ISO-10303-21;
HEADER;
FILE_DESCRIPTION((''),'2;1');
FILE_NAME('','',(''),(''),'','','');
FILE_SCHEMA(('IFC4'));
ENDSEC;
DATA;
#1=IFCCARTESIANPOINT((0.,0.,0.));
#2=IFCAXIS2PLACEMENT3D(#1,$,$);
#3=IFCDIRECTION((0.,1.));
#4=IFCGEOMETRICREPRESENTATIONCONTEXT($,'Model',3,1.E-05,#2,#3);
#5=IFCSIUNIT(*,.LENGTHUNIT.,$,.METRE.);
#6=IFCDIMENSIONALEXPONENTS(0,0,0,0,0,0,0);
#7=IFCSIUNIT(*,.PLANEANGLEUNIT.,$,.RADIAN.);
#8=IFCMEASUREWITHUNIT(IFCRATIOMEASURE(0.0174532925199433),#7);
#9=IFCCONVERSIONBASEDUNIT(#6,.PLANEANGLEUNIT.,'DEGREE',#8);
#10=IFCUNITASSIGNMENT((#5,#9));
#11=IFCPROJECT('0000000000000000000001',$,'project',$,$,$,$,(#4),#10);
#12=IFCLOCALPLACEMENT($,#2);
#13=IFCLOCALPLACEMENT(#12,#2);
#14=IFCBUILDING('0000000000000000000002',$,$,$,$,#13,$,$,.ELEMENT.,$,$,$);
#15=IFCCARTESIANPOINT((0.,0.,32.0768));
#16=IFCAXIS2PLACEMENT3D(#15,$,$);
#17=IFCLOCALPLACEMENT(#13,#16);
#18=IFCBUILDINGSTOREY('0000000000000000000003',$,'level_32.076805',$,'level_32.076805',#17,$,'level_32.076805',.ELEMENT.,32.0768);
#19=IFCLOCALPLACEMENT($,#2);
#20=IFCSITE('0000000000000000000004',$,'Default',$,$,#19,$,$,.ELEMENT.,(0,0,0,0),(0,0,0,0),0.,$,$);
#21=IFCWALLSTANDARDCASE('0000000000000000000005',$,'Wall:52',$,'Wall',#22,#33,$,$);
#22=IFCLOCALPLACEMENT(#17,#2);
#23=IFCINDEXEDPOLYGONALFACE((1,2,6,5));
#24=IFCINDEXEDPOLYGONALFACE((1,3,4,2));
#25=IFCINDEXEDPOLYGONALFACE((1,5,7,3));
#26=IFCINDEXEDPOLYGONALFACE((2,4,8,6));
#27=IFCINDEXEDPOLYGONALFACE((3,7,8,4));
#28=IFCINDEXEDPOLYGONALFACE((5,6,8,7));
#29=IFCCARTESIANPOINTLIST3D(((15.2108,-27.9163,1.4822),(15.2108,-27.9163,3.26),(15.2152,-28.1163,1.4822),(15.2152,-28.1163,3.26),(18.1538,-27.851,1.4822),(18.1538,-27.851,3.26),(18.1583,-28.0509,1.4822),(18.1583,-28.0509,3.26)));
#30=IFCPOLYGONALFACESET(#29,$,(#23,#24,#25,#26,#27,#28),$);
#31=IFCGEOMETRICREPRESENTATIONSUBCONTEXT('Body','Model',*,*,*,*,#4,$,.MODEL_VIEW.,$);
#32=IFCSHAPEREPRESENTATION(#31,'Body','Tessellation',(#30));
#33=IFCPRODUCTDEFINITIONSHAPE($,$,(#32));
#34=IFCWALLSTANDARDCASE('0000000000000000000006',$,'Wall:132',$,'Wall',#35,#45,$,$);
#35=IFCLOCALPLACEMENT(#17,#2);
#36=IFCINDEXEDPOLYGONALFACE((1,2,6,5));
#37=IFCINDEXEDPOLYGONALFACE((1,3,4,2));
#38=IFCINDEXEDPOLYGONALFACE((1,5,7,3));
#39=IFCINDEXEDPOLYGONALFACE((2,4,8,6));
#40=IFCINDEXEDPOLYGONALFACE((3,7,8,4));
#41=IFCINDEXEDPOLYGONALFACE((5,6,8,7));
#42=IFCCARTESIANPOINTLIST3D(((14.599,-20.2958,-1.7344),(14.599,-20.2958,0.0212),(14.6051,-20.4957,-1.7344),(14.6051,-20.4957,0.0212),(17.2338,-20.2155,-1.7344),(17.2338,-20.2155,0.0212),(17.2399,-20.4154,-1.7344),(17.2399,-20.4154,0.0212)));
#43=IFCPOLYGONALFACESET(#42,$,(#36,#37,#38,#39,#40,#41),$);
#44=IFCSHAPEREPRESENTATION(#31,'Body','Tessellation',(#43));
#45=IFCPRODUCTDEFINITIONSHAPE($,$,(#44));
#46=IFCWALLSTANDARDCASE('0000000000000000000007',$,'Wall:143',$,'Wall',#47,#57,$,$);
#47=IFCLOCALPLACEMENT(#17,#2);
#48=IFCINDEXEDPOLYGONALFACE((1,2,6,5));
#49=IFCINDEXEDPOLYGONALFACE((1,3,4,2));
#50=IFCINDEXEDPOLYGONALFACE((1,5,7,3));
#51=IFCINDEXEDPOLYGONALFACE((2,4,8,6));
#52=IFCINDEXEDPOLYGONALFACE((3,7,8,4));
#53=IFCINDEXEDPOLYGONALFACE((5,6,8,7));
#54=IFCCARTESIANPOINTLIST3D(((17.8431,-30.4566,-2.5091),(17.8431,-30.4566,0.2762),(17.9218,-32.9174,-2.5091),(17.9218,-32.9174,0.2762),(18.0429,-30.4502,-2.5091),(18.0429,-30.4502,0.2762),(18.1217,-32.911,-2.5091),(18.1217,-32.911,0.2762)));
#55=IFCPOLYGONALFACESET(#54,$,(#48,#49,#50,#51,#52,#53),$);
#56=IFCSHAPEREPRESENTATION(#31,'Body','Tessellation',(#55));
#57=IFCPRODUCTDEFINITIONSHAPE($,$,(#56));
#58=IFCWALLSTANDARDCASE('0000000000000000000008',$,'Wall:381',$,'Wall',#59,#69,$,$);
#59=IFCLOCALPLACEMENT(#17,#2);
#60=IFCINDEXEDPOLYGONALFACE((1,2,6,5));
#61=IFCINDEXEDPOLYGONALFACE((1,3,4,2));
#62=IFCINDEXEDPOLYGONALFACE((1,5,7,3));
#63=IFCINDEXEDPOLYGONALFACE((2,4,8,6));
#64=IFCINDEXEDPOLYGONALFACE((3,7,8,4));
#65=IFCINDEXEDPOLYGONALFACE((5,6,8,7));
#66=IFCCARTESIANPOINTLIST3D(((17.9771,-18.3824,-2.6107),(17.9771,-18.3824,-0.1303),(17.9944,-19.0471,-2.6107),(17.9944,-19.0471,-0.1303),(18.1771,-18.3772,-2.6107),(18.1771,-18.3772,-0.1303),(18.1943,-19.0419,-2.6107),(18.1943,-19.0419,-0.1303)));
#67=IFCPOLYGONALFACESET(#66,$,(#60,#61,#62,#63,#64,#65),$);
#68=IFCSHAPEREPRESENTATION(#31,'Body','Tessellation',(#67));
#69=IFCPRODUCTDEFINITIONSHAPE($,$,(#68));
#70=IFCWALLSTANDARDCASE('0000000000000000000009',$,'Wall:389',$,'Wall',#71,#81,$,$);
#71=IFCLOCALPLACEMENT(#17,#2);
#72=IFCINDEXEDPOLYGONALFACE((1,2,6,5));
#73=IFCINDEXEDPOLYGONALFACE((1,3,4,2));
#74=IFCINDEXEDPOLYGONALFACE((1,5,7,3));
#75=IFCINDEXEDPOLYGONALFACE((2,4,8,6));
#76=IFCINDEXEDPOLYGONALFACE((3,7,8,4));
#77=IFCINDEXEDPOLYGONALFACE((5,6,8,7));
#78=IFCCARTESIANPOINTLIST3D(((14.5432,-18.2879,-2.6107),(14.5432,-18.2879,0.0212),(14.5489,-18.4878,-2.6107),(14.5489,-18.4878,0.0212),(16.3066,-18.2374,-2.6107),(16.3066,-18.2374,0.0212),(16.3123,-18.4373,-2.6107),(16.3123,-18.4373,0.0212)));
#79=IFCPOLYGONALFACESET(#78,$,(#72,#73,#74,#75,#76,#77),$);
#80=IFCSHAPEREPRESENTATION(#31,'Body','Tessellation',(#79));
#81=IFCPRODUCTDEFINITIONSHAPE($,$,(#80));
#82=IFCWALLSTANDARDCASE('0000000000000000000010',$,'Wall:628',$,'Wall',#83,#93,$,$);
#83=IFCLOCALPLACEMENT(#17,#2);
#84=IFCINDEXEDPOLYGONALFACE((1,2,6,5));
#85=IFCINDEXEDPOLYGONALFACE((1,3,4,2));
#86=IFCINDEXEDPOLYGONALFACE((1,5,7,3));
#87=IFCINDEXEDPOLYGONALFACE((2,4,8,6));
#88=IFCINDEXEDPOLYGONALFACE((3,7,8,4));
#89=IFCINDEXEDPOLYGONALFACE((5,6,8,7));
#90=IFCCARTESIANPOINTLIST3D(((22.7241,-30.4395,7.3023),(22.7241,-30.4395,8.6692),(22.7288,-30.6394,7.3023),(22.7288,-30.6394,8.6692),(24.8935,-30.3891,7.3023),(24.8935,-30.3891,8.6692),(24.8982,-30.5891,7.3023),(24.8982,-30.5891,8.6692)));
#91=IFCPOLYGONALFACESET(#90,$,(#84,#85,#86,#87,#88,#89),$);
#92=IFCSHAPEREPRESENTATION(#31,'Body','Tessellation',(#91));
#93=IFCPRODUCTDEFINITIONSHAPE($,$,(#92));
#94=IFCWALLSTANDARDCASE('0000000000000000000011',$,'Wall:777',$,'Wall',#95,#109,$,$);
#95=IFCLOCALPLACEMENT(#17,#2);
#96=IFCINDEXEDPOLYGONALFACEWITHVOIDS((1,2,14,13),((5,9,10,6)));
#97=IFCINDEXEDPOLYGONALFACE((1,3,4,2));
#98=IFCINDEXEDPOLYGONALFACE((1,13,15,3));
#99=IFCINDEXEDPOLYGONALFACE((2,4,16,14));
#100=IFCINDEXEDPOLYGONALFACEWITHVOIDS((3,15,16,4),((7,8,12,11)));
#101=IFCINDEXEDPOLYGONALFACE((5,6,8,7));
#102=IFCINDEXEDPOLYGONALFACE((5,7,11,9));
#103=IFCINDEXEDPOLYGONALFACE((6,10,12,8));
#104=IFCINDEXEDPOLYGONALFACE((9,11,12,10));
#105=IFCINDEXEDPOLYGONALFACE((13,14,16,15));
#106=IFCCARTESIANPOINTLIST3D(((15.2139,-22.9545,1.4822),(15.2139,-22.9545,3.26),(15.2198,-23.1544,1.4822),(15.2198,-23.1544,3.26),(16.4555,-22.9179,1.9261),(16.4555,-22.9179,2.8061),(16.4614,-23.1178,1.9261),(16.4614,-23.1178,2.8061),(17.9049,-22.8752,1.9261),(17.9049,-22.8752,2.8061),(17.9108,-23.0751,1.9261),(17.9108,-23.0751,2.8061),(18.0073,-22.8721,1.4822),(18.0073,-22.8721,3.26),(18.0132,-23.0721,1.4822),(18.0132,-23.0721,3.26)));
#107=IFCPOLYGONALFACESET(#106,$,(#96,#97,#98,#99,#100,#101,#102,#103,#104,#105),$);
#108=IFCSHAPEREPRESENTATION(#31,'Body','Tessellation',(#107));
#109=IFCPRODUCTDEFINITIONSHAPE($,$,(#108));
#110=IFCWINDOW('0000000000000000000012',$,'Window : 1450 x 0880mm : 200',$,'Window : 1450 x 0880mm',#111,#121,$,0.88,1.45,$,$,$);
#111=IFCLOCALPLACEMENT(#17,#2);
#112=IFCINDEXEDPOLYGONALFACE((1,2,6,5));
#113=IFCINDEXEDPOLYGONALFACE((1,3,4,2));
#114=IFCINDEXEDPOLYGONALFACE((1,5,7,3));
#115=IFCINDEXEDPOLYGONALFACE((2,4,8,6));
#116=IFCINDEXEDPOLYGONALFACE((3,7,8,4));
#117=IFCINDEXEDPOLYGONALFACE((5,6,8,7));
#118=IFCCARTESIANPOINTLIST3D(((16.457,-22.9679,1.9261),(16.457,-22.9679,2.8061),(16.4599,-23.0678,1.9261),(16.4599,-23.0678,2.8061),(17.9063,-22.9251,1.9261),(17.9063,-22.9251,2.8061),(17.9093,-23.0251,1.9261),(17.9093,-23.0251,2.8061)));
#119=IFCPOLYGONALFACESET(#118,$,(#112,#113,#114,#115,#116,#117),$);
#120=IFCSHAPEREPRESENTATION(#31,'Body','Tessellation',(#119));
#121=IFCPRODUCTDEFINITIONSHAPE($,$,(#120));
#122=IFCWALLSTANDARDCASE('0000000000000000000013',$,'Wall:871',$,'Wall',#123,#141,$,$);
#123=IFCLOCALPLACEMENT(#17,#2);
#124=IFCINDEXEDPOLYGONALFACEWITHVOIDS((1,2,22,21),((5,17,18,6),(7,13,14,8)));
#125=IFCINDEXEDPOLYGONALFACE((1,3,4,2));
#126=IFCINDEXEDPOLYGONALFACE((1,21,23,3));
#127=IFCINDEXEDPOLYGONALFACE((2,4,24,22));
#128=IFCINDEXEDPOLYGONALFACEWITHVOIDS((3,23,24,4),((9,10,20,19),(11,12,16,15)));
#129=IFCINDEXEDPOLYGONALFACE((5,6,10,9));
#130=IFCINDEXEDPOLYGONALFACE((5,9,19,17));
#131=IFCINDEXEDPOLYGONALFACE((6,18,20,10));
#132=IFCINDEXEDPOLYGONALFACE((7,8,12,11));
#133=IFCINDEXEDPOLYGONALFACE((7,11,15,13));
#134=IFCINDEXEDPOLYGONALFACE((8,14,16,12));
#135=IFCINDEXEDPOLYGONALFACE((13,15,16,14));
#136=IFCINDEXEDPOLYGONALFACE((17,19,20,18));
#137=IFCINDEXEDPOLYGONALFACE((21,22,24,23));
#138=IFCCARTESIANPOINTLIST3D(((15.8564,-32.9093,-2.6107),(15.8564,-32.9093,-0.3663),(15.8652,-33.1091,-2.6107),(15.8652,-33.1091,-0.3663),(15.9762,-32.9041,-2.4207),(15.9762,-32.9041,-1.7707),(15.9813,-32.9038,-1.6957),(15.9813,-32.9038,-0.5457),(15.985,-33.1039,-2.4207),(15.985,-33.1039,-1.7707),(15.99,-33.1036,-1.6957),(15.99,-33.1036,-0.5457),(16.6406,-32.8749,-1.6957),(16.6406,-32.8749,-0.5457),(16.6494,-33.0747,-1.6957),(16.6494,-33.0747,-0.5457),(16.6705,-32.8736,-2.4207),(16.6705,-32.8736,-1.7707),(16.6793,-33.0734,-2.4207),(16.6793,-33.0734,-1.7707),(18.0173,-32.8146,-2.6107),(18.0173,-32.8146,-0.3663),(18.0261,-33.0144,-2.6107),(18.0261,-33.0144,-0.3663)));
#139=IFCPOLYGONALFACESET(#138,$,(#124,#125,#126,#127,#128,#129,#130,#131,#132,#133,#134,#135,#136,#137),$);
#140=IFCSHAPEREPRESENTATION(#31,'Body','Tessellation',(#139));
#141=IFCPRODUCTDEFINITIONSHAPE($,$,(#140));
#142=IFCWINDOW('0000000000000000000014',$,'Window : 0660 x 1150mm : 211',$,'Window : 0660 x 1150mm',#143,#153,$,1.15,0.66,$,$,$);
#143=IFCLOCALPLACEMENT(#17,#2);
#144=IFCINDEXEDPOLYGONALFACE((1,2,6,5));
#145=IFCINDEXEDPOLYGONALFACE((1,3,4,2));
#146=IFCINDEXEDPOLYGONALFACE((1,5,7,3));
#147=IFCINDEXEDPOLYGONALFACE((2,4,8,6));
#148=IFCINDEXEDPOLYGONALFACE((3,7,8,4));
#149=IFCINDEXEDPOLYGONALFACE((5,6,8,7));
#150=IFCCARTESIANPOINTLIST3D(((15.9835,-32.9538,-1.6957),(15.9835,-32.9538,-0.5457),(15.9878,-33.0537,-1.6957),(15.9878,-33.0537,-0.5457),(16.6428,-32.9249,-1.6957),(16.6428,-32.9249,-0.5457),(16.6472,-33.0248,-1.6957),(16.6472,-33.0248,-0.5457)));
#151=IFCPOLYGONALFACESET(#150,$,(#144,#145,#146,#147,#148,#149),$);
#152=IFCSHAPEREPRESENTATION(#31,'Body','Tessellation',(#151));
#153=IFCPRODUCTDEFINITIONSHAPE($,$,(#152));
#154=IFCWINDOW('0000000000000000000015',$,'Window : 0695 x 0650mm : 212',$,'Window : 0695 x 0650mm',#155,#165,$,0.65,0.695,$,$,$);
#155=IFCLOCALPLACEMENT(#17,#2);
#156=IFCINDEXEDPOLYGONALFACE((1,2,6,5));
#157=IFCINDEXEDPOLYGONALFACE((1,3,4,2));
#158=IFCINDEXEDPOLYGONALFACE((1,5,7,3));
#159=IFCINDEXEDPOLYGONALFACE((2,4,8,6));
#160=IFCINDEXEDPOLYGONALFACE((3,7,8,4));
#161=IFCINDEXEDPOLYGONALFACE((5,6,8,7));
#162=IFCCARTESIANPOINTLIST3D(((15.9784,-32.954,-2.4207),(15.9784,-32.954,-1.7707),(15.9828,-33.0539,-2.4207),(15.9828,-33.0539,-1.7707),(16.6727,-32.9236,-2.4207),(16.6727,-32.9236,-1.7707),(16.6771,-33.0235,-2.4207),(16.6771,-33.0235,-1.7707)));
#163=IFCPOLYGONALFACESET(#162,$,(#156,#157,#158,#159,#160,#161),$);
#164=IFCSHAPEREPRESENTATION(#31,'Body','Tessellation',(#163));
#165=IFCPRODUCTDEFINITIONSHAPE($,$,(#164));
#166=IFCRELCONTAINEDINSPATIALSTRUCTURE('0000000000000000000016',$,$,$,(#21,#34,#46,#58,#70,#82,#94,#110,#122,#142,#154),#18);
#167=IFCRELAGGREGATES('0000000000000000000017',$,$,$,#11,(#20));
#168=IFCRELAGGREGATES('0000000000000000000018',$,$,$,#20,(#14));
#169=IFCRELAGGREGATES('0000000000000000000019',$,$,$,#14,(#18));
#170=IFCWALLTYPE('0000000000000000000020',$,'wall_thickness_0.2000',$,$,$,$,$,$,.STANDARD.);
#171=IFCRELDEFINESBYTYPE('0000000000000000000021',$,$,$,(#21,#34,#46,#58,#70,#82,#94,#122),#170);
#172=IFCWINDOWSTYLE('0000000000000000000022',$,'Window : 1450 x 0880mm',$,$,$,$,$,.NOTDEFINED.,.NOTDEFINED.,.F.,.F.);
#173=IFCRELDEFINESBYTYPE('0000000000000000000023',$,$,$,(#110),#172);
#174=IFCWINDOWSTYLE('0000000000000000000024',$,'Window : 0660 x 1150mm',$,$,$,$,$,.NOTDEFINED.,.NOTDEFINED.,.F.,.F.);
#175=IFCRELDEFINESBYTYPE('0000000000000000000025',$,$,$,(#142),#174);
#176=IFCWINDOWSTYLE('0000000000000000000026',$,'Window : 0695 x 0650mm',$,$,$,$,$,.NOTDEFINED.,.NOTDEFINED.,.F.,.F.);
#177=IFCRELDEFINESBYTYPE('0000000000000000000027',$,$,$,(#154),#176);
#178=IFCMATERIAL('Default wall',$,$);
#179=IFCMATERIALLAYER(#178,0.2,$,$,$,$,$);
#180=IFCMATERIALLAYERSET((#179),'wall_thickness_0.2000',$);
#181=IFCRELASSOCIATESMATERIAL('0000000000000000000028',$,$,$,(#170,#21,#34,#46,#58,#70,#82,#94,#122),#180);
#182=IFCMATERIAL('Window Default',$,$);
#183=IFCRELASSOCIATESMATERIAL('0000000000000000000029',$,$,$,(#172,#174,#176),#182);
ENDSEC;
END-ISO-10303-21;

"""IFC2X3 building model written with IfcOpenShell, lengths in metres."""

from ifc_helpers import new_model, entity, si_unit, converted_unit, direction, frame, frame_2d, origin, origin_2d_with_axis, place, context, subcontext, project, spatial, polyline, rectangle, outline, extrude, source, transform, mapped, material, layer, layer_set, layer_usage, type_object, type_shapes, element, fill, save


model = new_model("IFC2X3")

# Units and contexts
model_context = context("Model", 3, precision=1e-05, world=origin(), true_north=direction((0.0, 1.0)))
body_context = subcontext(model_context, "Body", "Model", "MODEL_VIEW")
ifc_project = project(units=[si_unit("LENGTHUNIT", "METRE"), converted_unit("PLANEANGLEUNIT", "DEGREE", entity("IfcRatioMeasure", 0.0174532925199433), si_unit("PLANEANGLEUNIT", "RADIAN"), dimensions=[0, 0, 0, 0, 0, 0, 0])], contexts=[model_context])

# Site, building, storey
site_placement = place(None, origin())
site = spatial("IfcSite", under=ifc_project, at=site_placement, Name="Default", CompositionType="ELEMENT", RefLatitude=(0, 0, 0, 0), RefLongitude=(0, 0, 0, 0), RefElevation=0.0)
placement_1 = place(None, origin())
building_placement = place(placement_1, origin())
building = spatial("IfcBuilding", under=site, at=building_placement, CompositionType="ELEMENT")
storey_placement = place(building_placement, frame((0.0, 0.0, 32.0768)))
storey = spatial("IfcBuildingStorey", under=building, at=storey_placement, Name="level_32.076805", ObjectType="level_32.076805", LongName="level_32.076805", CompositionType="ELEMENT", Elevation=32.0768)

# Walls
ifc_material_1 = material(Name="Default wall")
ifc_layer = layer(ifc_material_1, 0.2)
ifc_layer_set = layer_set([ifc_layer], Name="wall_thickness_0.2000")
ifc_layer_usage = layer_usage(ifc_layer_set, "AXIS2", "POSITIVE", -0.1)
wall_type = type_object("IfcWallType", Name="wall_thickness_0.2000", PredefinedType="STANDARD", material=ifc_layer_set)
placement_2 = place(building_placement, frame((0.0, 0.0, 33.559)))
wall_1_placement = place(placement_2, frame((15.213, -28.0163, 0.0), z_axis=(0.0, 0.0, 1.0), x_axis=(0.999753, 0.022205, 0.0)))
element("IfcWallStandardCase", 1, at=wall_1_placement, inside=storey, type_object=wall_type, material=ifc_layer_usage, Name="Wall:52", ObjectType="Wall", context=body_context, shape_type="SweptSolid", body=[
    extrude(outline(polyline([(2.9438, -0.1), (2.9438, 0.1), (0.0, 0.1), (0.0, -0.1), (2.9438, -0.1)])), origin(), (0.0, 0.0, 1.0), 1.7778),
])
placement_3 = place(building_placement, frame((0.0, 0.0, 30.3424)))
wall_2_placement = place(placement_3, frame((14.6021, -20.3957, 0.0), z_axis=(0.0, 0.0, 1.0), x_axis=(0.999535, 0.030477, 0.0)))
element("IfcWallStandardCase", 2, at=wall_2_placement, inside=storey, type_object=wall_type, material=ifc_layer_usage, Name="Wall:132", ObjectType="Wall", context=body_context, shape_type="SweptSolid", body=[
    extrude(outline(polyline([(2.636, -0.1), (2.636, 0.1), (0.0, 0.1), (0.0, -0.1), (2.636, -0.1)])), origin(), (0.0, 0.0, 1.0), 1.7557),
])
placement_4 = place(building_placement, frame((0.0, 0.0, 29.5677)))
wall_3_placement = place(placement_4, frame((18.0217, -32.9142, 0.0), z_axis=(0.0, 0.0, 1.0), x_axis=(-0.031966, 0.999489, 0.0)))
element("IfcWallStandardCase", 3, at=wall_3_placement, inside=storey, type_object=wall_type, material=ifc_layer_usage, Name="Wall:143", ObjectType="Wall", context=body_context, shape_type="SweptSolid", body=[
    extrude(outline(polyline([(2.4621, -0.1), (2.4621, 0.1), (0.0, 0.1), (0.0, -0.1), (2.4621, -0.1)])), origin(), (0.0, 0.0, 1.0), 2.7852),
])
placement_5 = place(building_placement, frame((0.0, 0.0, 29.4661)))
wall_4_placement = place(placement_5, frame((18.0771, -18.3798, 0.0), z_axis=(0.0, 0.0, 1.0), x_axis=(0.025986, -0.999662, 0.0)))
element("IfcWallStandardCase", 4, at=wall_4_placement, inside=storey, type_object=wall_type, material=ifc_layer_usage, Name="Wall:381", ObjectType="Wall", context=body_context, shape_type="SweptSolid", body=[
    extrude(outline(polyline([(0.665, -0.1), (0.665, 0.1), (0.0, 0.1), (0.0, -0.1), (0.665, -0.1)])), origin(), (0.0, 0.0, 1.0), 2.4805),
])
placement_6 = place(building_placement, frame((0.0, 0.0, 29.4661)))
wall_5_placement = place(placement_6, frame((16.3094, -18.3374, 0.0), z_axis=(0.0, 0.0, 1.0), x_axis=(-0.99959, -0.02862, 0.0)))
element("IfcWallStandardCase", 5, at=wall_5_placement, inside=storey, type_object=wall_type, material=ifc_layer_usage, Name="Wall:389", ObjectType="Wall", context=body_context, shape_type="SweptSolid", body=[
    extrude(outline(polyline([(1.7641, -0.1), (1.7641, 0.1), (0.0, 0.1), (0.0, -0.1), (1.7641, -0.1)])), origin(), (0.0, 0.0, 1.0), 2.632),
])
placement_7 = place(building_placement, frame((0.0, 0.0, 39.3791)))
wall_6_placement = place(placement_7, frame((22.7264, -30.5395, 0.0), z_axis=(0.0, 0.0, 1.0), x_axis=(0.999731, 0.023204, 0.0)))
element("IfcWallStandardCase", 6, at=wall_6_placement, inside=storey, type_object=wall_type, material=ifc_layer_usage, Name="Wall:628", ObjectType="Wall", context=body_context, shape_type="SweptSolid", body=[
    extrude(outline(polyline([(2.17, -0.1), (2.17, 0.1), (0.0, 0.1), (0.0, -0.1), (2.17, -0.1)])), origin(), (0.0, 0.0, 1.0), 1.3669),
])

# Wall, opening, window
placement_8 = place(building_placement, frame((0.0, 0.0, 33.559)))
wall_7_placement = place(placement_8, frame((15.2168, -23.0545, 0.0), z_axis=(0.0, 0.0, 1.0), x_axis=(0.999565, 0.029478, 0.0)))
wall_7 = element("IfcWallStandardCase", 7, at=wall_7_placement, inside=storey, type_object=wall_type, material=ifc_layer_usage, Name="Wall:777", ObjectType="Wall", context=body_context, shape_type="SweptSolid", body=[
    extrude(outline(polyline([(2.7947, -0.1), (2.7947, 0.1), (0.0, 0.1), (0.0, -0.1), (2.7947, -0.1)])), origin(), (0.0, 0.0, 1.0), 1.7778),
])
opening_1_placement = place(wall_7_placement, frame((1.2421, -0.1, 0.444)))
opening_1 = element("IfcOpeningElement", 8, at=opening_1_placement, cuts=wall_7, ObjectType="Opening", context=body_context, shape_type="SweptSolid", body=[
    extrude(rectangle(XDim=1.45, YDim=0.88, at=frame_2d((0.44, 0.725), x_axis=(0.0, 1.0))), frame((0.0, 0.0, 0.0), z_axis=(0.0, 1.0, 0.0), x_axis=(0.0, 0.0, 1.0)), (0.0, 0.0, 1.0), 0.2),
])
ifc_material_2 = material(Name="Window Default")
window_style_1 = type_object("IfcWindowStyle", Name="Window : 1450 x 0880mm", ConstructionType="NOTDEFINED", OperationType="NOTDEFINED", ParameterTakesPrecedence=False, Sizeable=False, material=ifc_material_2)
shared_shape_1 = source(origin(), body_context, "Body", "SweptSolid", [
    extrude(rectangle(XDim=0.1, YDim=1.45, at=origin_2d_with_axis()), frame((0.725, 0.1, 0.0), z_axis=(0.0, 0.0, 1.0), x_axis=(0.0, 1.0, 0.0)), (0.0, 0.0, 1.0), 0.88),
])
type_shapes(window_style_1, [shared_shape_1])
window_1_placement = place(opening_1_placement, origin())
window_1 = element("IfcWindow", 9, at=window_1_placement, inside=storey, type_object=window_style_1, Name="Window : 1450 x 0880mm : 200", ObjectType="Window : 1450 x 0880mm", OverallHeight=0.88, OverallWidth=1.45, context=body_context, shape_type="MappedRepresentation", body=[
    mapped(shared_shape_1, transform((0.0, 0.0, 0.0), scale=1.0)),
])
fill(opening_1, window_1)

# Wall, openings, windows
placement_9 = place(building_placement, frame((0.0, 0.0, 29.4661)))
wall_8_placement = place(placement_9, frame((18.0217, -32.9145, 0.0), z_axis=(0.0, 0.0, 1.0), x_axis=(-0.999041, -0.043775, 0.0)))
wall_8 = element("IfcWallStandardCase", 10, at=wall_8_placement, inside=storey, type_object=wall_type, material=ifc_layer_usage, Name="Wall:871", ObjectType="Wall", context=body_context, shape_type="SweptSolid", body=[
    extrude(outline(polyline([(2.163, -0.1), (2.163, 0.1), (0.0, 0.1), (0.0, -0.1), (2.163, -0.1)])), origin(), (0.0, 0.0, 1.0), 2.2444),
])
opening_2_placement = place(wall_8_placement, frame((1.378, -0.1, 0.9151)))
opening_2 = element("IfcOpeningElement", 11, at=opening_2_placement, cuts=wall_8, ObjectType="Opening", context=body_context, shape_type="SweptSolid", body=[
    extrude(rectangle(XDim=0.66, YDim=1.15, at=frame_2d((0.575, 0.33), x_axis=(0.0, 1.0))), frame((0.0, 0.0, 0.0), z_axis=(0.0, 1.0, 0.0), x_axis=(0.0, 0.0, 1.0)), (0.0, 0.0, 1.0), 0.2),
])
opening_3_placement = place(wall_8_placement, frame((1.3481, -0.1, 0.1901)))
opening_3 = element("IfcOpeningElement", 12, at=opening_3_placement, cuts=wall_8, ObjectType="Opening", context=body_context, shape_type="SweptSolid", body=[
    extrude(rectangle(XDim=0.695, YDim=0.65, at=frame_2d((0.325, 0.3475), x_axis=(0.0, 1.0))), frame((0.0, 0.0, 0.0), z_axis=(0.0, 1.0, 0.0), x_axis=(0.0, 0.0, 1.0)), (0.0, 0.0, 1.0), 0.2),
])
window_style_2 = type_object("IfcWindowStyle", Name="Window : 0660 x 1150mm", ConstructionType="NOTDEFINED", OperationType="NOTDEFINED", ParameterTakesPrecedence=False, Sizeable=False, material=ifc_material_2)
shared_shape_2 = source(origin(), body_context, "Body", "SweptSolid", [
    extrude(rectangle(XDim=0.1, YDim=0.66, at=origin_2d_with_axis()), frame((0.33, 0.1, 0.0), z_axis=(0.0, 0.0, 1.0), x_axis=(0.0, 1.0, 0.0)), (0.0, 0.0, 1.0), 1.15),
])
type_shapes(window_style_2, [shared_shape_2])
window_2_placement = place(opening_2_placement, origin())
window_2 = element("IfcWindow", 13, at=window_2_placement, inside=storey, type_object=window_style_2, Name="Window : 0660 x 1150mm : 211", ObjectType="Window : 0660 x 1150mm", OverallHeight=1.15, OverallWidth=0.66, context=body_context, shape_type="MappedRepresentation", body=[
    mapped(shared_shape_2, transform((0.0, 0.0, 0.0), scale=1.0)),
])
fill(opening_2, window_2)
window_style_3 = type_object("IfcWindowStyle", Name="Window : 0695 x 0650mm", ConstructionType="NOTDEFINED", OperationType="NOTDEFINED", ParameterTakesPrecedence=False, Sizeable=False, material=ifc_material_2)
shared_shape_3 = source(origin(), body_context, "Body", "SweptSolid", [
    extrude(rectangle(XDim=0.1, YDim=0.695, at=origin_2d_with_axis()), frame((0.3475, 0.1, 0.0), z_axis=(0.0, 0.0, 1.0), x_axis=(0.0, 1.0, 0.0)), (0.0, 0.0, 1.0), 0.65),
])
type_shapes(window_style_3, [shared_shape_3])
window_3_placement = place(opening_3_placement, origin())
window_3 = element("IfcWindow", 14, at=window_3_placement, inside=storey, type_object=window_style_3, Name="Window : 0695 x 0650mm : 212", ObjectType="Window : 0695 x 0650mm", OverallHeight=0.65, OverallWidth=0.695, context=body_context, shape_type="MappedRepresentation", body=[
    mapped(shared_shape_3, transform((0.0, 0.0, 0.0), scale=1.0)),
])
fill(opening_3, window_3)

save(model, "model.ifc")
